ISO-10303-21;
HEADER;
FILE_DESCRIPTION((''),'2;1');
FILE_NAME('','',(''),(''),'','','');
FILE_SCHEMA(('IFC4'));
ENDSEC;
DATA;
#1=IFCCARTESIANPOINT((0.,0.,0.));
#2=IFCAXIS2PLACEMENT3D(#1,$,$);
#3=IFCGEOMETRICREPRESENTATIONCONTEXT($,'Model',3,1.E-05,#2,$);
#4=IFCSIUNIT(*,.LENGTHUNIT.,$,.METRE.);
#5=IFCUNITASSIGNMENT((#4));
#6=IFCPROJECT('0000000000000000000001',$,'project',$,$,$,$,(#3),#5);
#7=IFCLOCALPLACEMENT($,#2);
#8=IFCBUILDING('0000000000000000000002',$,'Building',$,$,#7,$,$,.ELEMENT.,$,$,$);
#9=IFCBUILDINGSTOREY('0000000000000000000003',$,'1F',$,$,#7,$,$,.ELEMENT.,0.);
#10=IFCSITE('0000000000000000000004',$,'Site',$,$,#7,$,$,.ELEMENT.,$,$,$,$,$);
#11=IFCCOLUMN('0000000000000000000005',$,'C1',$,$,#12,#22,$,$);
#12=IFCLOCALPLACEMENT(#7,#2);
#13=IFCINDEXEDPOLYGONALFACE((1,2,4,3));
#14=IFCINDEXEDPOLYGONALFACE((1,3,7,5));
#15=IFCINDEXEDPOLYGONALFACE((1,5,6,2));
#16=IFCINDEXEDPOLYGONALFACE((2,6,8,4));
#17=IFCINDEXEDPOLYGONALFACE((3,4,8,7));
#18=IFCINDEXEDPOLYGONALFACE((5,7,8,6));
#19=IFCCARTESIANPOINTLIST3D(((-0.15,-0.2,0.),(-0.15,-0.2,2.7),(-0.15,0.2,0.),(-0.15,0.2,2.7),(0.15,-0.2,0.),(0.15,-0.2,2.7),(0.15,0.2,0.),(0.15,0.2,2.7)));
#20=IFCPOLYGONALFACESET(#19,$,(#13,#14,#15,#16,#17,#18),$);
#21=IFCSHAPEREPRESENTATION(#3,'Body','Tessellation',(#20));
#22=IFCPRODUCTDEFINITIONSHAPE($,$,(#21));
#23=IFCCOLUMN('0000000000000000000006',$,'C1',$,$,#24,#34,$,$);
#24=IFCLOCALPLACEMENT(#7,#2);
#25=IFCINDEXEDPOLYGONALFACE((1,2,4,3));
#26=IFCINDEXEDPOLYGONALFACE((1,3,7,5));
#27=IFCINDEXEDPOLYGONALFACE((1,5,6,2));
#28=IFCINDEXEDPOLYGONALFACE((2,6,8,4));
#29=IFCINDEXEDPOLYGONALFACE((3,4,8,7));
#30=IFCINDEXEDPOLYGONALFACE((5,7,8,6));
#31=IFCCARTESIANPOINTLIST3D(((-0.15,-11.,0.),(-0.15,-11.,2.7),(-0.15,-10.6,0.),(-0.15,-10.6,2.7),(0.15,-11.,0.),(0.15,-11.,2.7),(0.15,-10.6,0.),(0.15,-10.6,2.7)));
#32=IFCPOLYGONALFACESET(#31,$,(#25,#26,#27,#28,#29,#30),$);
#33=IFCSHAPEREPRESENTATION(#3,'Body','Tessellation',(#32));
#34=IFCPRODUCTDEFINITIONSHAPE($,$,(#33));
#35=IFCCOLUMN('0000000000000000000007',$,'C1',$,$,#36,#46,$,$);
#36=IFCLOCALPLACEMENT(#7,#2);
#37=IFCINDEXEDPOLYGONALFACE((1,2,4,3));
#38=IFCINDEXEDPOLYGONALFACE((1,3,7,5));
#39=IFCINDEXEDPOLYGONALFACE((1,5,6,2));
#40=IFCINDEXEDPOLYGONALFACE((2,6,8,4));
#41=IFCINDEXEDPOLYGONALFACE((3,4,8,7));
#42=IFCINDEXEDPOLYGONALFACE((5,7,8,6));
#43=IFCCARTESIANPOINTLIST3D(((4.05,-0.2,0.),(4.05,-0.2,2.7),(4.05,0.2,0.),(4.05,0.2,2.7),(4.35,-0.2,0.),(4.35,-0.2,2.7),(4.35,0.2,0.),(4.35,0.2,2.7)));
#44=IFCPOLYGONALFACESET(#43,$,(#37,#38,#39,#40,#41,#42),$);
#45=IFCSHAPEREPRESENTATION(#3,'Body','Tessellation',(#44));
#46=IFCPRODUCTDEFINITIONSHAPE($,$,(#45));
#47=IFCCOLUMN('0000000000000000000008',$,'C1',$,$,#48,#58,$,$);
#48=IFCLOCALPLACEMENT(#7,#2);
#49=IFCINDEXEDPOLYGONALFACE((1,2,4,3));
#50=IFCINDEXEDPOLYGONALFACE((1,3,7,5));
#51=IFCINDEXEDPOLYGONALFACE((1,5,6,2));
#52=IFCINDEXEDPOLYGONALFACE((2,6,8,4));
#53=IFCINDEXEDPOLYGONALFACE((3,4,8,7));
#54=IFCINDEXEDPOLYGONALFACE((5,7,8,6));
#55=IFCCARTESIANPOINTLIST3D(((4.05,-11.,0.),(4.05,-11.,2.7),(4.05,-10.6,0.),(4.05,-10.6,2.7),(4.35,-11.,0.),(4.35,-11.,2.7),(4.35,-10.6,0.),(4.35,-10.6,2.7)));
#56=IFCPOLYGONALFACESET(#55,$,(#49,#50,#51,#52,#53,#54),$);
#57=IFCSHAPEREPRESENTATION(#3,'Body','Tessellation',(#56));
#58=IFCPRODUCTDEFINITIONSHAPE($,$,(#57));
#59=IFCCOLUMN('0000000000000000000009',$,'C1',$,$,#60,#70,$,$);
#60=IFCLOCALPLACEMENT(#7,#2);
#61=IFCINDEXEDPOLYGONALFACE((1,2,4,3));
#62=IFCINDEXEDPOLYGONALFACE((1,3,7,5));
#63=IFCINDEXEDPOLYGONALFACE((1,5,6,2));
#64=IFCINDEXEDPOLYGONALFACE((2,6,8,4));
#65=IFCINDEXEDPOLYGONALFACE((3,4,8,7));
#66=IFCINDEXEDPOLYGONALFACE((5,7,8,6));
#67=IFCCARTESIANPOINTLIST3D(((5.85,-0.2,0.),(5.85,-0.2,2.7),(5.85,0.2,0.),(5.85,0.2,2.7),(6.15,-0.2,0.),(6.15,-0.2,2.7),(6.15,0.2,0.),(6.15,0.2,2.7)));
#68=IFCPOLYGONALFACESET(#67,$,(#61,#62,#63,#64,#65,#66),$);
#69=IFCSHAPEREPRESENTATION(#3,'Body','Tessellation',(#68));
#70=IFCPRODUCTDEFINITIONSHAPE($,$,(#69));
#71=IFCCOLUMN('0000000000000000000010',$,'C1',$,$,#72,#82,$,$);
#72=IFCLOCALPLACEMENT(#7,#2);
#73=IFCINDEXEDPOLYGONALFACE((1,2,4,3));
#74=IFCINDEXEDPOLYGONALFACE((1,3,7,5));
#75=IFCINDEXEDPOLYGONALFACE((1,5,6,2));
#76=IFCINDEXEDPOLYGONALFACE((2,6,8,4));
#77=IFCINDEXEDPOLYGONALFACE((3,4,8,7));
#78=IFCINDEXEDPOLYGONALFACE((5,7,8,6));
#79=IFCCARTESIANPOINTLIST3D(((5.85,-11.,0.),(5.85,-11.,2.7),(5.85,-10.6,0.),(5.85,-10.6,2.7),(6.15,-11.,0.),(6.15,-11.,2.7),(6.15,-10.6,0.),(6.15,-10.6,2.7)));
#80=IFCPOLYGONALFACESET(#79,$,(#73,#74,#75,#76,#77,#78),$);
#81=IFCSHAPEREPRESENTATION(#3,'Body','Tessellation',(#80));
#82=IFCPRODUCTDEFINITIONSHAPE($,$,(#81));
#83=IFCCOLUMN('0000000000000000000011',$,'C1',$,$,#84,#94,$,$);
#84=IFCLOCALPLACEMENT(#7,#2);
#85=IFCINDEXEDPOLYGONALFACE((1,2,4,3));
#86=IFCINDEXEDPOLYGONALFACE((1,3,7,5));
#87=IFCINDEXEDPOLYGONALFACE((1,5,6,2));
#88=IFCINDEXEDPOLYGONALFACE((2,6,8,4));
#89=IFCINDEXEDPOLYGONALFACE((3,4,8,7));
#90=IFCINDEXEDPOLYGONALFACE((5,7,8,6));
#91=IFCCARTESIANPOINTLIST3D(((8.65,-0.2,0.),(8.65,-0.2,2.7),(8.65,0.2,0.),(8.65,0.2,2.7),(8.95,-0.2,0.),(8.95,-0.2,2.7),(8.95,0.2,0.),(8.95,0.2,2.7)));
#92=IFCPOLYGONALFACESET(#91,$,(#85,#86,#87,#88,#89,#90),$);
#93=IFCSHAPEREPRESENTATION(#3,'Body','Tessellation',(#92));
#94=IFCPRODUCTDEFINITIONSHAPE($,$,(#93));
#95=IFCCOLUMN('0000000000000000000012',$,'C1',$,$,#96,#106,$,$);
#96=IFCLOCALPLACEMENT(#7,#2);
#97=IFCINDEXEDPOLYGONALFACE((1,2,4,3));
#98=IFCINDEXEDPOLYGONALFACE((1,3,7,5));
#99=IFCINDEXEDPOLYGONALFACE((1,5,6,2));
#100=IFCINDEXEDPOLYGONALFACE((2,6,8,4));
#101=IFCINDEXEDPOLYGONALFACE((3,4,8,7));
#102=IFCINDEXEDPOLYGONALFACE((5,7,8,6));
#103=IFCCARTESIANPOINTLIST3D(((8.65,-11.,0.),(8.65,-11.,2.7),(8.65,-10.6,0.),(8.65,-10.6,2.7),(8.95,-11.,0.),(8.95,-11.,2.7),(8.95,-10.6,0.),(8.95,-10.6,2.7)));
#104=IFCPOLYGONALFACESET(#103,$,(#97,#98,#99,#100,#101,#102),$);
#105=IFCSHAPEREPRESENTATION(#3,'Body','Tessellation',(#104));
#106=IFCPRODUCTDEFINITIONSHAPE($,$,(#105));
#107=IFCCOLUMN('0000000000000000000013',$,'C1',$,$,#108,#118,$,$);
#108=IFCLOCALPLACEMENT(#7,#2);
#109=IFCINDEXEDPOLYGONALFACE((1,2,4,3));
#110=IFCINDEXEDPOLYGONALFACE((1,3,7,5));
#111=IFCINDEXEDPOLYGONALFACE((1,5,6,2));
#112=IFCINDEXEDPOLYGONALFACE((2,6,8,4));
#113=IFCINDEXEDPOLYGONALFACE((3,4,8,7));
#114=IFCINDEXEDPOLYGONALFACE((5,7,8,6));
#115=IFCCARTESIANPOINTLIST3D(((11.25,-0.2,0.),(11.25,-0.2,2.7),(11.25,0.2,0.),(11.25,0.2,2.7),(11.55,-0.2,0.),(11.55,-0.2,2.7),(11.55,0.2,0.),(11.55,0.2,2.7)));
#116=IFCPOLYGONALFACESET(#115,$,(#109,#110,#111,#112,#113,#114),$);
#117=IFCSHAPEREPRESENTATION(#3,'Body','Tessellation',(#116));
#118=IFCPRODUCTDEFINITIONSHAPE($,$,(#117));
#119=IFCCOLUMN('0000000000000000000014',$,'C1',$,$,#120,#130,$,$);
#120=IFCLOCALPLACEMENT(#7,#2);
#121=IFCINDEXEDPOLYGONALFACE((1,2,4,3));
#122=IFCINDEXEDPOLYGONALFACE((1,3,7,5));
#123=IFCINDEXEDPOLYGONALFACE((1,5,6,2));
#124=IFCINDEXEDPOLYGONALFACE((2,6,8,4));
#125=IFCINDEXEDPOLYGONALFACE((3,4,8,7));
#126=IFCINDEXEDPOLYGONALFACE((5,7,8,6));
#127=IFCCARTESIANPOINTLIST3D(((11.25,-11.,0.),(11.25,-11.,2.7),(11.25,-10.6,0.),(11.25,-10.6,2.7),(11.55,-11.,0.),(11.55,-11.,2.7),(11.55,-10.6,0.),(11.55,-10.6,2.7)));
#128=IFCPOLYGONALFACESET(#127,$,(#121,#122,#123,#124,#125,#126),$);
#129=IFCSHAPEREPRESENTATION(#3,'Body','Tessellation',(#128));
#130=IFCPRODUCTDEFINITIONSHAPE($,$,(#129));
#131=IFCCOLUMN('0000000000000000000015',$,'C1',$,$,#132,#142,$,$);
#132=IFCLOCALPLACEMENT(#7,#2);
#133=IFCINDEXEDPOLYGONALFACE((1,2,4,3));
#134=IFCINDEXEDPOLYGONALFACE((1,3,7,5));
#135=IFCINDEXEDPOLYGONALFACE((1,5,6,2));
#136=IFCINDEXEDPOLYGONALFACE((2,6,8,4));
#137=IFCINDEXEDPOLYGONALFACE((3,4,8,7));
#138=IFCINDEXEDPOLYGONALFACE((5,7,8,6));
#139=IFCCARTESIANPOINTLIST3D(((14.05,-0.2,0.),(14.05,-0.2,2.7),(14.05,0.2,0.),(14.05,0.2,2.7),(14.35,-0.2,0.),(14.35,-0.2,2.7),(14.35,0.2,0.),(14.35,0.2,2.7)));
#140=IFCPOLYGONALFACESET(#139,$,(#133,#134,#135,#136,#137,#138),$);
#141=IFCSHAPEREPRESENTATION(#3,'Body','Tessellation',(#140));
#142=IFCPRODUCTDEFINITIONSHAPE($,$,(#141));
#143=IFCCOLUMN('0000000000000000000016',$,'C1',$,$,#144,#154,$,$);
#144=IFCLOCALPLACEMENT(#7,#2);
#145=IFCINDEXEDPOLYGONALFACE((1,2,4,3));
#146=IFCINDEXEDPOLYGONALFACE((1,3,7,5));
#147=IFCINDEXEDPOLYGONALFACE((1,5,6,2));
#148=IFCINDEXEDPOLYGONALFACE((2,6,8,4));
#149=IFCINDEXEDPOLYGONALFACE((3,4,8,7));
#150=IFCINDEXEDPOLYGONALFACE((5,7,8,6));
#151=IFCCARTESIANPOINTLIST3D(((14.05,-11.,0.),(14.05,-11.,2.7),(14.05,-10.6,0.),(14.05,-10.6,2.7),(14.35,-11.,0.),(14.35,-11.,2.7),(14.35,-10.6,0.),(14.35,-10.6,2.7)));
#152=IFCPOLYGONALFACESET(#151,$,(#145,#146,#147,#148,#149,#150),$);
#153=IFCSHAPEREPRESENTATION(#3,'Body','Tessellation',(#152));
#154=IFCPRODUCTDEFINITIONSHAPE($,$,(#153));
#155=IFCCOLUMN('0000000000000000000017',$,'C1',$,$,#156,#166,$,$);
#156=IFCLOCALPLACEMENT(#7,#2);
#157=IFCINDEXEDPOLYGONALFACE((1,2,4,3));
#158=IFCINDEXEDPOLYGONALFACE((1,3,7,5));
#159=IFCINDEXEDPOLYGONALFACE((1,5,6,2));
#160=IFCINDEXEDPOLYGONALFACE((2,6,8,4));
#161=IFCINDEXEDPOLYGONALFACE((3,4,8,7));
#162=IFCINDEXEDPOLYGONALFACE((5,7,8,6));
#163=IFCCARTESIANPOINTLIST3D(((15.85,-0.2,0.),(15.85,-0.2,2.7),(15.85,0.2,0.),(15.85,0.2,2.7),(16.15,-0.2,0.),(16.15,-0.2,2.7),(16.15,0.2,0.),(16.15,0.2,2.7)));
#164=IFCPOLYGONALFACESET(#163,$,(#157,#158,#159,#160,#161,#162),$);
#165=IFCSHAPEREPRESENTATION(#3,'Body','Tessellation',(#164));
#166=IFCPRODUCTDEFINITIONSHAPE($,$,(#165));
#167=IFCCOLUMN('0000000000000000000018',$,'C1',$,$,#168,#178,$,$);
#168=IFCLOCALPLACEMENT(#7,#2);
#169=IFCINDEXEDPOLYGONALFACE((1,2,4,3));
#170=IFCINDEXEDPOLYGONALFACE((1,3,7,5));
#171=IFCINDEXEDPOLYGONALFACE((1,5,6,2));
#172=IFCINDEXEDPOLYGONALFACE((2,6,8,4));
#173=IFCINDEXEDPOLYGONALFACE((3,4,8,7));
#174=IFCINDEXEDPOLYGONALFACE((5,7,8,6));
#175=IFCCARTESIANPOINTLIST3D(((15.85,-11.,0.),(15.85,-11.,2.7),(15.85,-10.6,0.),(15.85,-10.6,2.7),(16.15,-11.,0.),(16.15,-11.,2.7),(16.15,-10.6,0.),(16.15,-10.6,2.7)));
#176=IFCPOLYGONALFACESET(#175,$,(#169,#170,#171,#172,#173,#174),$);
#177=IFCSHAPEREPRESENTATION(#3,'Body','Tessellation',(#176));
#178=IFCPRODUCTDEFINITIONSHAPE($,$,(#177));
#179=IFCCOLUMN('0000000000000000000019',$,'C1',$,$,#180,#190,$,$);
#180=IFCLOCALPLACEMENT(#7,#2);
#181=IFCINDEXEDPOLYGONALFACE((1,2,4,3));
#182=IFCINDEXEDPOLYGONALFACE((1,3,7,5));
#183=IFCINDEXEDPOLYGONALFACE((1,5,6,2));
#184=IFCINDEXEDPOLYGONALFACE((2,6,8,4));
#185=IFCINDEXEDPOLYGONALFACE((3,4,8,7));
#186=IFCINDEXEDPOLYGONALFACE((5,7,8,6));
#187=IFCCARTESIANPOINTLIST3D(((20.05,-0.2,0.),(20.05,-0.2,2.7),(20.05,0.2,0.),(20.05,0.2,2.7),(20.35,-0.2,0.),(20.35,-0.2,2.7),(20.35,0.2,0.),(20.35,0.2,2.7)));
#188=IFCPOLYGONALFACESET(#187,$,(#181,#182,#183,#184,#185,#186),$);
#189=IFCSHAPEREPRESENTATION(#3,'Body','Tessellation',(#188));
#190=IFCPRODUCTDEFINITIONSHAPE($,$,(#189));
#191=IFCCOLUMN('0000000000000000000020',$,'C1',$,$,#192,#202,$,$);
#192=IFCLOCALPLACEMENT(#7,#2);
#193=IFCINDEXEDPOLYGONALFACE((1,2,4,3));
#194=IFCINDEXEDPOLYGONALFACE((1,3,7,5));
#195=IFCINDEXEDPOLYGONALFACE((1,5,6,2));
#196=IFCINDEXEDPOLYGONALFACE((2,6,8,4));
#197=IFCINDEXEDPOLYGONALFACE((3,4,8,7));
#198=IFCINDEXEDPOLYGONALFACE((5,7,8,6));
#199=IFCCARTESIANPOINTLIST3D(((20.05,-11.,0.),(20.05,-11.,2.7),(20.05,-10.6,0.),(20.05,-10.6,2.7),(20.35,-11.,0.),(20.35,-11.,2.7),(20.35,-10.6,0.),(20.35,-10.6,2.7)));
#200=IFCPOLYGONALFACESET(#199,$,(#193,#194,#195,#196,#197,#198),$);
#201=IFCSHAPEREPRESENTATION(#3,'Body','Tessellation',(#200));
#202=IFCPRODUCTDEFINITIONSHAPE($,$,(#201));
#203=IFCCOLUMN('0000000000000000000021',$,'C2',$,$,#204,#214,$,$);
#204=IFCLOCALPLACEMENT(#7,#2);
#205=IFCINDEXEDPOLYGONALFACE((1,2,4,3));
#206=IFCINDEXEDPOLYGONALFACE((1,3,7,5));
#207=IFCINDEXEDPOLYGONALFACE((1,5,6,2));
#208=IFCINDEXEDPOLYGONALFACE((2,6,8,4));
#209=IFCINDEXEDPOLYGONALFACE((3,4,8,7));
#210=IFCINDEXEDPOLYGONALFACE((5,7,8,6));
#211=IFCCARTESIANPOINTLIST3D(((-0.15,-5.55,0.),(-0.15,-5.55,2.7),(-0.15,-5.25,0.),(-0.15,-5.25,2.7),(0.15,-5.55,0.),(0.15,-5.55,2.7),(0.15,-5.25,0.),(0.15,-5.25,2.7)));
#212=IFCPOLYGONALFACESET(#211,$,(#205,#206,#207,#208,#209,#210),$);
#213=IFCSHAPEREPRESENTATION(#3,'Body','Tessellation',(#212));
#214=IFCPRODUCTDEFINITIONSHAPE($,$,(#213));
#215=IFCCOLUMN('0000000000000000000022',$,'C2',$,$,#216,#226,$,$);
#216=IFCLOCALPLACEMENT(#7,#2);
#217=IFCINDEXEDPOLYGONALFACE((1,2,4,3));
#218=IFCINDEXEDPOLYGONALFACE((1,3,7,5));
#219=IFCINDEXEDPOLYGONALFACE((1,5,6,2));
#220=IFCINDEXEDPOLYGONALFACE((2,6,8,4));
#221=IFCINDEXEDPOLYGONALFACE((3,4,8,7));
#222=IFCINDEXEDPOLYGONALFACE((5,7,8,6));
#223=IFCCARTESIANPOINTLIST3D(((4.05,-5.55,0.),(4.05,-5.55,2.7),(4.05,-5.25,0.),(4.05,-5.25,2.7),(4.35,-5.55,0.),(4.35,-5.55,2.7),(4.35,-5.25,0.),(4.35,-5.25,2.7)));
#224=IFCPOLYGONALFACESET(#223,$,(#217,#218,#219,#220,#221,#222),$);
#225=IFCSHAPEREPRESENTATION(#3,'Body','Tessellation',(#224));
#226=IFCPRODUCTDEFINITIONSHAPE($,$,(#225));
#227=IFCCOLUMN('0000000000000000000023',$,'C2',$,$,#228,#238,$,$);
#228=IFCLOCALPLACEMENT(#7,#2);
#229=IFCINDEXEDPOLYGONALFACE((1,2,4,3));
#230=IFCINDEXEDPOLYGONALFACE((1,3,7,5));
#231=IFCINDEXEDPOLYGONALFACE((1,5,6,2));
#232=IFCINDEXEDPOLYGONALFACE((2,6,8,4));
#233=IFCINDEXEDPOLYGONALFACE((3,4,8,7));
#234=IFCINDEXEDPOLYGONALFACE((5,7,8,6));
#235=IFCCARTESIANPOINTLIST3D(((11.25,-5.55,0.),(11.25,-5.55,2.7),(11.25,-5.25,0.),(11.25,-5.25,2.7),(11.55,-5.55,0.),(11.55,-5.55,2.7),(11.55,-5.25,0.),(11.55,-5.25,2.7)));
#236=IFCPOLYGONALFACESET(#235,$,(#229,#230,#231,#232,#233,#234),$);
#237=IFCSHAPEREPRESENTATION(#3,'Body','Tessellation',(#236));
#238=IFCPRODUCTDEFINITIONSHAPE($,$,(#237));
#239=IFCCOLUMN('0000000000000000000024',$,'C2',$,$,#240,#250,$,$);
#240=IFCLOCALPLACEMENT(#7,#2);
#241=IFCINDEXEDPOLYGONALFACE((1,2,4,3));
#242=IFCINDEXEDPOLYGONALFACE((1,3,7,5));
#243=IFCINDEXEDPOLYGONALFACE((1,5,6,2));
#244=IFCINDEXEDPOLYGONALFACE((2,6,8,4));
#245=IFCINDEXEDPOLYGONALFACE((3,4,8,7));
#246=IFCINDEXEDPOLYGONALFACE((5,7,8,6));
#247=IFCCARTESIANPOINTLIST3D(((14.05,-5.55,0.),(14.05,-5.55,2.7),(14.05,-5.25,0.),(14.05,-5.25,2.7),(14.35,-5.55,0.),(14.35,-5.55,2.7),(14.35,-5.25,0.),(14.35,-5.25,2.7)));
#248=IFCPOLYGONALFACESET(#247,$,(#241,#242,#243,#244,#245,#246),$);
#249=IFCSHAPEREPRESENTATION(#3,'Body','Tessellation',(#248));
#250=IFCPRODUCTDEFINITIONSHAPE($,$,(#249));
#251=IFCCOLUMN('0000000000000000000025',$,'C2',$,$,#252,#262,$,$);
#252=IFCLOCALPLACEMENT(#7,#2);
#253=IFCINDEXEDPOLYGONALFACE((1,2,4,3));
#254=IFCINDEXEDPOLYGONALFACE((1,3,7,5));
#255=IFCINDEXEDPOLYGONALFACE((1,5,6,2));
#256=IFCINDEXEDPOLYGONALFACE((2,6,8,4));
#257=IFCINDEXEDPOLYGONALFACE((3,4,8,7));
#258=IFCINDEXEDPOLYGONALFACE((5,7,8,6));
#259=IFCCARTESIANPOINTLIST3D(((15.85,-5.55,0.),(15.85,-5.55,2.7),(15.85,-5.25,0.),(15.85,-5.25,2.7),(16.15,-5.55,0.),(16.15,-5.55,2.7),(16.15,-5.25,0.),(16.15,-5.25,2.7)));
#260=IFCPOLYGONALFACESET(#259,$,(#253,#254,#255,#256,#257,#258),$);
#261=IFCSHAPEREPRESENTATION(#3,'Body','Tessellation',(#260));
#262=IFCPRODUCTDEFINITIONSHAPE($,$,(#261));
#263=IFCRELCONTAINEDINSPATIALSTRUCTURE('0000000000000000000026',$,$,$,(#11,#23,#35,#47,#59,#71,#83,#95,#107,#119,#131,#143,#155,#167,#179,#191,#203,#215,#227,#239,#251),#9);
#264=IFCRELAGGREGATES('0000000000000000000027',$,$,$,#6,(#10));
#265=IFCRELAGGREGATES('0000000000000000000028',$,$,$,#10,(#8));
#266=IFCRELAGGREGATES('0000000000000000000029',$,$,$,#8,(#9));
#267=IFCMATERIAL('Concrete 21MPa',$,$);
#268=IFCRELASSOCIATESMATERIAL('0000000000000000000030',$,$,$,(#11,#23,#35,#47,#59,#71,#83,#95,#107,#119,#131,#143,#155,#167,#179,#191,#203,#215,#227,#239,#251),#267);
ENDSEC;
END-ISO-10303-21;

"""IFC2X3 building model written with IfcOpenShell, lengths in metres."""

from ifc_helpers import new_model, si_unit, frame, origin, origin_2d, place, context, project, spatial, rectangle, extrude, material, element, save


model = new_model("IFC2X3")

# Units and contexts
model_context = context("Model", 3, precision=1e-05, world=origin())
ifc_project = project(units=[si_unit("LENGTHUNIT", "METRE")], contexts=[model_context])

# Site, building, storey
placement = place(None, origin())
site = spatial("IfcSite", under=ifc_project, at=placement, Name="Site", CompositionType="ELEMENT")
building = spatial("IfcBuilding", under=site, at=placement, Name="Building", CompositionType="ELEMENT")
storey = spatial("IfcBuildingStorey", under=building, at=placement, Name="1F", CompositionType="ELEMENT", Elevation=0.0)

# Columns
ifc_material = material(Name="Concrete 21MPa")
for number, where, name in (
    (1, (0.0, 0.0, 0.0), "C1"),
    (2, (0.0, -10.8, 0.0), "C1"),
    (3, (4.2, 0.0, 0.0), "C1"),
    (4, (4.2, -10.8, 0.0), "C1"),
    (5, (6.0, 0.0, 0.0), "C1"),
    (6, (6.0, -10.8, 0.0), "C1"),
    (7, (8.8, 0.0, 0.0), "C1"),
    (8, (8.8, -10.8, 0.0), "C1"),
    (9, (11.4, 0.0, 0.0), "C1"),
    (10, (11.4, -10.8, 0.0), "C1"),
    (11, (14.2, 0.0, 0.0), "C1"),
    (12, (14.2, -10.8, 0.0), "C1"),
    (13, (16.0, 0.0, 0.0), "C1"),
    (14, (16.0, -10.8, 0.0), "C1"),
    (15, (20.2, 0.0, 0.0), "C1"),
    (16, (20.2, -10.8, 0.0), "C1"),
):
    element("IfcColumn", number, at=place(None, frame(where)), inside=storey, material=ifc_material, Name=name, context=model_context, shape_type="SweptSolid", body=[
        extrude(rectangle(XDim=0.3, YDim=0.4, at=origin_2d()), origin(), (0.0, 0.0, 1.0), 2.7),
    ])
for number, where, name in (
    (17, (0.0, -5.4, 0.0), "C2"),
    (18, (4.2, -5.4, 0.0), "C2"),
    (19, (11.4, -5.4, 0.0), "C2"),
    (20, (14.2, -5.4, 0.0), "C2"),
    (21, (16.0, -5.4, 0.0), "C2"),
):
    element("IfcColumn", number, at=place(None, frame(where)), inside=storey, material=ifc_material, Name=name, context=model_context, shape_type="SweptSolid", body=[
        extrude(rectangle(XDim=0.3, YDim=0.3, at=origin_2d()), origin(), (0.0, 0.0, 1.0), 2.7),
    ])

save(model, "model.ifc")
